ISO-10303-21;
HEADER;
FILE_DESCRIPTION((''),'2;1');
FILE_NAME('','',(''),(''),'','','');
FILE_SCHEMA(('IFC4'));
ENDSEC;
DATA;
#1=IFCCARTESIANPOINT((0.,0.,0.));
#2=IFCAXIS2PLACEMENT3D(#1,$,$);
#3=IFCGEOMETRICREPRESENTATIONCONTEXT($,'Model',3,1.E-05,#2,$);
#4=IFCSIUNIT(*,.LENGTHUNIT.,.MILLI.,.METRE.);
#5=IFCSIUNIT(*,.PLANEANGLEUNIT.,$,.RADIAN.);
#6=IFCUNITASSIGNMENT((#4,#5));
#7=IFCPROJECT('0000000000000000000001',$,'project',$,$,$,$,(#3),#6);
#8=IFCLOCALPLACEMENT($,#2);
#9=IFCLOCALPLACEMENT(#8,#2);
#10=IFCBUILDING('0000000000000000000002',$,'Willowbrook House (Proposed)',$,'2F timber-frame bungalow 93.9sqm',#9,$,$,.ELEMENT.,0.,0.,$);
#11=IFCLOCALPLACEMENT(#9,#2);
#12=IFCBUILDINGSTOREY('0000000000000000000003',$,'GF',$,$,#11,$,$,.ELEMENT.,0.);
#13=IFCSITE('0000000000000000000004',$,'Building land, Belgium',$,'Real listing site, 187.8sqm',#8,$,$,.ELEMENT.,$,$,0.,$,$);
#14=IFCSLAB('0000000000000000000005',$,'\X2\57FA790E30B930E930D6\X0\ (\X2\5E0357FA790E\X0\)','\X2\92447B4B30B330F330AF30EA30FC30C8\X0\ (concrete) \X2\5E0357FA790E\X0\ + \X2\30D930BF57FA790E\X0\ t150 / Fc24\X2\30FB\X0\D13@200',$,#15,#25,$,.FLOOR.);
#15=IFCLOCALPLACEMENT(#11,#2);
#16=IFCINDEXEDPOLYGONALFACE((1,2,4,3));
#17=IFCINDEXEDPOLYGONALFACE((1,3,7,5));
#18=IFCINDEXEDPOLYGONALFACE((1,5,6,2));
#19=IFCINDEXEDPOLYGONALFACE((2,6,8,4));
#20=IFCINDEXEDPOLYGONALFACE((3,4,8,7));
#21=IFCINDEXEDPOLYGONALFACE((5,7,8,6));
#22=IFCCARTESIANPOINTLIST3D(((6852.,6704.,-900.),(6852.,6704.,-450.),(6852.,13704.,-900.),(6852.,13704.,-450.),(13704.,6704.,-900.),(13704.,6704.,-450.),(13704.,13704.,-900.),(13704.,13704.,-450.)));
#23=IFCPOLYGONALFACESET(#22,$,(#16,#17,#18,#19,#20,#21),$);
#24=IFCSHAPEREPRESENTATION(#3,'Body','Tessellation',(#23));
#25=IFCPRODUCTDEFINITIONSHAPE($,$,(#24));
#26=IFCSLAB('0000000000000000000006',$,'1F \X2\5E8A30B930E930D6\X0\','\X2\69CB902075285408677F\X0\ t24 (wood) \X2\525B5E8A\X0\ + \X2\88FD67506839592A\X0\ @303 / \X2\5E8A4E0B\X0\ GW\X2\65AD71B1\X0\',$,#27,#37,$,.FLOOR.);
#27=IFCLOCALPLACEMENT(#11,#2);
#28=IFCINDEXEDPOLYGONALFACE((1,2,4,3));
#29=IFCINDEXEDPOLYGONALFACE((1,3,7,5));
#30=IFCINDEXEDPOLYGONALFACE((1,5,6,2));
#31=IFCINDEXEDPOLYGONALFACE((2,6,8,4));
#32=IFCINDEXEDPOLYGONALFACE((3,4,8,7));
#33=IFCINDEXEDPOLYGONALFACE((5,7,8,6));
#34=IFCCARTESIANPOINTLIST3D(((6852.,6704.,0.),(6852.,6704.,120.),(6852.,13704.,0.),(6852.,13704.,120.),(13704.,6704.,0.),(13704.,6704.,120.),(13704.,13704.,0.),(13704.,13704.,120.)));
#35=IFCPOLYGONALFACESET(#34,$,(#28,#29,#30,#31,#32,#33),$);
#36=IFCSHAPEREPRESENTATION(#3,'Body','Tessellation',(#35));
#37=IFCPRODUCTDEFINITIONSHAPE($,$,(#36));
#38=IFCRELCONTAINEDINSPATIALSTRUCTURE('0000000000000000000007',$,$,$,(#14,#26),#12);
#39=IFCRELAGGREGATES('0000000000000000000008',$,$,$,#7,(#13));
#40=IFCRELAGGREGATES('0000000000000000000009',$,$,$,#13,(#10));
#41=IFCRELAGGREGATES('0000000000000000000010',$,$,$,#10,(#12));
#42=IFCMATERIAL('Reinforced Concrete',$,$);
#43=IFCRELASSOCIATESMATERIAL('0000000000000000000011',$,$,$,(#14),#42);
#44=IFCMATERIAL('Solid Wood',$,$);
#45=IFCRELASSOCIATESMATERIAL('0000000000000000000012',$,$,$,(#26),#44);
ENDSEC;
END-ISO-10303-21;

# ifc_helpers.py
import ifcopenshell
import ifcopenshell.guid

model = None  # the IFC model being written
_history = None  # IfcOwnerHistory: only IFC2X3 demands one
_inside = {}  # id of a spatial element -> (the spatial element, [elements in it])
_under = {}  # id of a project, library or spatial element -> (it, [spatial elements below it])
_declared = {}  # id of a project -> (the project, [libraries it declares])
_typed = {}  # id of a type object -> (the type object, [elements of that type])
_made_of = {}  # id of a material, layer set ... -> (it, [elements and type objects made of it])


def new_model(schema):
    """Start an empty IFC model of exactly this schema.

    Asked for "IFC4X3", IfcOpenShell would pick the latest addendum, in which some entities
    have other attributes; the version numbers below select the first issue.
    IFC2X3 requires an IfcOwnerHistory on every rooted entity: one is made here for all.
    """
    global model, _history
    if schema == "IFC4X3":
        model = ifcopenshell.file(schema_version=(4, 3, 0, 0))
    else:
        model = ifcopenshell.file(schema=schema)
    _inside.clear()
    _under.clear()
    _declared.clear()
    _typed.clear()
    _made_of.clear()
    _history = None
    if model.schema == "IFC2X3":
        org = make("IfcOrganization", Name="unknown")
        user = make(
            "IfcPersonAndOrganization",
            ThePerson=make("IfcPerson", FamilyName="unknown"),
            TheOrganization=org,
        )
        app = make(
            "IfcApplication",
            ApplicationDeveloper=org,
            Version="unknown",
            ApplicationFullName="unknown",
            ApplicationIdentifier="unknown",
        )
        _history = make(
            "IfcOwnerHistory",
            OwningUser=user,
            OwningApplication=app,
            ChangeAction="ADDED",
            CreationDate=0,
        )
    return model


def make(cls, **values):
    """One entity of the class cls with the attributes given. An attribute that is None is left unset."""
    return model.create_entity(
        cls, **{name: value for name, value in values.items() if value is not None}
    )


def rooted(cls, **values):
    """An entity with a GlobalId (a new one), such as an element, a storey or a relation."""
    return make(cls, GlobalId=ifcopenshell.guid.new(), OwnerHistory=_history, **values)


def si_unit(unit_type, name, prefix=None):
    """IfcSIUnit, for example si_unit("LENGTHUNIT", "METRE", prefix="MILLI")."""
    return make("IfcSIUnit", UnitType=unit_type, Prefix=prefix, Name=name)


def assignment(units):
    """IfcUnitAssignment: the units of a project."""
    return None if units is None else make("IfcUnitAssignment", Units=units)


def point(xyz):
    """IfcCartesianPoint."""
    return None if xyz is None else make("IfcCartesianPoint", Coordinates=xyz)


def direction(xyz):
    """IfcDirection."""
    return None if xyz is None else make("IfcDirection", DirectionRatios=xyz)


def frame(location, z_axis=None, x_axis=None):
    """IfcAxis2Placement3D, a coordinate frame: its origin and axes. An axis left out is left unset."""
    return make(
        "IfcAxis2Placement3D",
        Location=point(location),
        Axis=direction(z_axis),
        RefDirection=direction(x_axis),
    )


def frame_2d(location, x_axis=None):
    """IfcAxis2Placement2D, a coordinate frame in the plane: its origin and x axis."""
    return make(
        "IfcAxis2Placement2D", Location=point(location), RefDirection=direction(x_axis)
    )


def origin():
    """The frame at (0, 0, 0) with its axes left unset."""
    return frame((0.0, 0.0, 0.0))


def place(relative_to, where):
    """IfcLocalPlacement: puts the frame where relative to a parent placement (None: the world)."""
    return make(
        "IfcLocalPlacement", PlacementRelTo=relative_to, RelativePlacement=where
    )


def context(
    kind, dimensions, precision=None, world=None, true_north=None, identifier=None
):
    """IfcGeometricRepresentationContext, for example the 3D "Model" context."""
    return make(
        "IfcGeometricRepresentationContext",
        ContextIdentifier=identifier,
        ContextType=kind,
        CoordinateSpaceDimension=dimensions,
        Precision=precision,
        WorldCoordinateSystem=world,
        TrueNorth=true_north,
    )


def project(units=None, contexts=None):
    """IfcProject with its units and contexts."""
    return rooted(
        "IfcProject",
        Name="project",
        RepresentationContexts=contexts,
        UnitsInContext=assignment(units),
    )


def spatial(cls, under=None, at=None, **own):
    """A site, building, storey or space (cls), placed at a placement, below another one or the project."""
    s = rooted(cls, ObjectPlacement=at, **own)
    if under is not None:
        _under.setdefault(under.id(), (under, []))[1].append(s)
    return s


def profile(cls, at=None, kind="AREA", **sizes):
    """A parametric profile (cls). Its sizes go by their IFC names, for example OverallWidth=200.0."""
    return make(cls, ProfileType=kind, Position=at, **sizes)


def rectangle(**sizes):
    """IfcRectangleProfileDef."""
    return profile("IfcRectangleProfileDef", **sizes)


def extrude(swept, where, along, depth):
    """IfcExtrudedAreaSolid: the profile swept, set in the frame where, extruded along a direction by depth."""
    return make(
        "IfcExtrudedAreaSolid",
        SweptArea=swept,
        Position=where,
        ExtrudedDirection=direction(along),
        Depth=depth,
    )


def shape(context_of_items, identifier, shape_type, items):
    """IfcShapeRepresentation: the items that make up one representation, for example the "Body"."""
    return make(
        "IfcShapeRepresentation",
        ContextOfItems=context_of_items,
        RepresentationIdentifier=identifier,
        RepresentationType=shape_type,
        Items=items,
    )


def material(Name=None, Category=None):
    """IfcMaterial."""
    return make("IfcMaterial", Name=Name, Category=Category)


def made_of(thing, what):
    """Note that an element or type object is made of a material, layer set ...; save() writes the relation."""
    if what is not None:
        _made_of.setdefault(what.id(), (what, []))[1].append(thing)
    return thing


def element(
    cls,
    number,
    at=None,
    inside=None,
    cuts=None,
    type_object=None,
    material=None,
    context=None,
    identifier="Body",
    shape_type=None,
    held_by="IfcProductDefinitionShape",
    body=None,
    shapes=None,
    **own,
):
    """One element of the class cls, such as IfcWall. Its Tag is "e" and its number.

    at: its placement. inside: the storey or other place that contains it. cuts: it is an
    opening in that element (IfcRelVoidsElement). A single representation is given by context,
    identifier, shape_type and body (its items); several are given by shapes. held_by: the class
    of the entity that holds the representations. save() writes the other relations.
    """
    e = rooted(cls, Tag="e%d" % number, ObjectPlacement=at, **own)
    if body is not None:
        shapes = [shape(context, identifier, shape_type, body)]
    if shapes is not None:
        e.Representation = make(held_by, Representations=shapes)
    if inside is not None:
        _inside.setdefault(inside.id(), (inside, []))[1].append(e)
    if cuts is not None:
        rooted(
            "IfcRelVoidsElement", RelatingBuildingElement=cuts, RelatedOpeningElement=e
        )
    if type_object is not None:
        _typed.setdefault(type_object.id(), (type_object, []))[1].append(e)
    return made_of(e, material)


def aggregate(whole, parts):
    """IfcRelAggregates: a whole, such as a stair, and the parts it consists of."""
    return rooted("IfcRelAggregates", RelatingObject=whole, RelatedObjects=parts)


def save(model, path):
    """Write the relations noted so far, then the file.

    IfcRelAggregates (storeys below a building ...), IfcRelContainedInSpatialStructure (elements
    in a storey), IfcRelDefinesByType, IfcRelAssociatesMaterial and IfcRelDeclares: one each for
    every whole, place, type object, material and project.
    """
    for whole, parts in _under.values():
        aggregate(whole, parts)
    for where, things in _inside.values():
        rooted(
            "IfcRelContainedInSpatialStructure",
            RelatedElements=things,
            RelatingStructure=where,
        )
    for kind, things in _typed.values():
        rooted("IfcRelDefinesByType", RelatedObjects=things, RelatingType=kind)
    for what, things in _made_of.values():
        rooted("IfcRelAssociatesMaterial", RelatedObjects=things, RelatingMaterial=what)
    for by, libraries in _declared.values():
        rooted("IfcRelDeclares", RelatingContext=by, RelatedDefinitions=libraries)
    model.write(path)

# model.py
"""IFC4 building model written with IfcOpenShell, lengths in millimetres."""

from ifc_helpers import new_model, si_unit, frame, frame_2d, origin, place, context, project, spatial, rectangle, extrude, material, element, save


model = new_model("IFC4")

# Units and contexts
model_context = context("Model", 3, precision=1e-05, world=origin())
ifc_project = project(units=[si_unit("LENGTHUNIT", "METRE", prefix="MILLI"), si_unit("PLANEANGLEUNIT", "RADIAN")], contexts=[model_context])

# Site, building, storey
site_placement = place(None, origin())
site = spatial("IfcSite", under=ifc_project, at=site_placement, Name="Building land, Belgium", ObjectType="Real listing site, 187.8sqm", CompositionType="ELEMENT", RefElevation=0.0)
building_placement = place(site_placement, origin())
building = spatial("IfcBuilding", under=site, at=building_placement, Name="Willowbrook House (Proposed)", ObjectType="2F timber-frame bungalow 93.9sqm", CompositionType="ELEMENT", ElevationOfRefHeight=0.0, ElevationOfTerrain=0.0)
storey_placement = place(building_placement, origin())
storey = spatial("IfcBuildingStorey", under=building, at=storey_placement, Name="GF", CompositionType="ELEMENT", Elevation=0.0)

# Slabs
ifc_material_1 = material(Name="Reinforced Concrete")
slab_1_placement = place(storey_placement, frame((3426.0, 3352.0, -450.0)))
element("IfcSlab", 1, at=slab_1_placement, inside=storey, material=ifc_material_1, Name="基礎スラブ (布基礎)", Description="鉄筋コンクリート (concrete) 布基礎 + ベタ基礎 t150 / Fc24・D13@200", PredefinedType="FLOOR", context=model_context, shape_type="SweptSolid", body=[
    extrude(rectangle(XDim=6852.0, YDim=7000.0, at=frame_2d((3426.0, 3500.0))), frame((3426.0, 3352.0, -450.0)), (0.0, 0.0, 1.0), 450.0),
])
ifc_material_2 = material(Name="Solid Wood")
slab_2_placement = place(storey_placement, frame((3426.0, 3352.0, 0.0)))
element("IfcSlab", 2, at=slab_2_placement, inside=storey, material=ifc_material_2, Name="1F 床スラブ", Description="構造用合板 t24 (wood) 剛床 + 製材根太 @303 / 床下 GW断熱", PredefinedType="FLOOR", context=model_context, shape_type="SweptSolid", body=[
    extrude(rectangle(XDim=6852.0, YDim=7000.0, at=frame_2d((3426.0, 3500.0))), frame((3426.0, 3352.0, 0.0)), (0.0, 0.0, 1.0), 120.0),
])

save(model, "model.ifc")
